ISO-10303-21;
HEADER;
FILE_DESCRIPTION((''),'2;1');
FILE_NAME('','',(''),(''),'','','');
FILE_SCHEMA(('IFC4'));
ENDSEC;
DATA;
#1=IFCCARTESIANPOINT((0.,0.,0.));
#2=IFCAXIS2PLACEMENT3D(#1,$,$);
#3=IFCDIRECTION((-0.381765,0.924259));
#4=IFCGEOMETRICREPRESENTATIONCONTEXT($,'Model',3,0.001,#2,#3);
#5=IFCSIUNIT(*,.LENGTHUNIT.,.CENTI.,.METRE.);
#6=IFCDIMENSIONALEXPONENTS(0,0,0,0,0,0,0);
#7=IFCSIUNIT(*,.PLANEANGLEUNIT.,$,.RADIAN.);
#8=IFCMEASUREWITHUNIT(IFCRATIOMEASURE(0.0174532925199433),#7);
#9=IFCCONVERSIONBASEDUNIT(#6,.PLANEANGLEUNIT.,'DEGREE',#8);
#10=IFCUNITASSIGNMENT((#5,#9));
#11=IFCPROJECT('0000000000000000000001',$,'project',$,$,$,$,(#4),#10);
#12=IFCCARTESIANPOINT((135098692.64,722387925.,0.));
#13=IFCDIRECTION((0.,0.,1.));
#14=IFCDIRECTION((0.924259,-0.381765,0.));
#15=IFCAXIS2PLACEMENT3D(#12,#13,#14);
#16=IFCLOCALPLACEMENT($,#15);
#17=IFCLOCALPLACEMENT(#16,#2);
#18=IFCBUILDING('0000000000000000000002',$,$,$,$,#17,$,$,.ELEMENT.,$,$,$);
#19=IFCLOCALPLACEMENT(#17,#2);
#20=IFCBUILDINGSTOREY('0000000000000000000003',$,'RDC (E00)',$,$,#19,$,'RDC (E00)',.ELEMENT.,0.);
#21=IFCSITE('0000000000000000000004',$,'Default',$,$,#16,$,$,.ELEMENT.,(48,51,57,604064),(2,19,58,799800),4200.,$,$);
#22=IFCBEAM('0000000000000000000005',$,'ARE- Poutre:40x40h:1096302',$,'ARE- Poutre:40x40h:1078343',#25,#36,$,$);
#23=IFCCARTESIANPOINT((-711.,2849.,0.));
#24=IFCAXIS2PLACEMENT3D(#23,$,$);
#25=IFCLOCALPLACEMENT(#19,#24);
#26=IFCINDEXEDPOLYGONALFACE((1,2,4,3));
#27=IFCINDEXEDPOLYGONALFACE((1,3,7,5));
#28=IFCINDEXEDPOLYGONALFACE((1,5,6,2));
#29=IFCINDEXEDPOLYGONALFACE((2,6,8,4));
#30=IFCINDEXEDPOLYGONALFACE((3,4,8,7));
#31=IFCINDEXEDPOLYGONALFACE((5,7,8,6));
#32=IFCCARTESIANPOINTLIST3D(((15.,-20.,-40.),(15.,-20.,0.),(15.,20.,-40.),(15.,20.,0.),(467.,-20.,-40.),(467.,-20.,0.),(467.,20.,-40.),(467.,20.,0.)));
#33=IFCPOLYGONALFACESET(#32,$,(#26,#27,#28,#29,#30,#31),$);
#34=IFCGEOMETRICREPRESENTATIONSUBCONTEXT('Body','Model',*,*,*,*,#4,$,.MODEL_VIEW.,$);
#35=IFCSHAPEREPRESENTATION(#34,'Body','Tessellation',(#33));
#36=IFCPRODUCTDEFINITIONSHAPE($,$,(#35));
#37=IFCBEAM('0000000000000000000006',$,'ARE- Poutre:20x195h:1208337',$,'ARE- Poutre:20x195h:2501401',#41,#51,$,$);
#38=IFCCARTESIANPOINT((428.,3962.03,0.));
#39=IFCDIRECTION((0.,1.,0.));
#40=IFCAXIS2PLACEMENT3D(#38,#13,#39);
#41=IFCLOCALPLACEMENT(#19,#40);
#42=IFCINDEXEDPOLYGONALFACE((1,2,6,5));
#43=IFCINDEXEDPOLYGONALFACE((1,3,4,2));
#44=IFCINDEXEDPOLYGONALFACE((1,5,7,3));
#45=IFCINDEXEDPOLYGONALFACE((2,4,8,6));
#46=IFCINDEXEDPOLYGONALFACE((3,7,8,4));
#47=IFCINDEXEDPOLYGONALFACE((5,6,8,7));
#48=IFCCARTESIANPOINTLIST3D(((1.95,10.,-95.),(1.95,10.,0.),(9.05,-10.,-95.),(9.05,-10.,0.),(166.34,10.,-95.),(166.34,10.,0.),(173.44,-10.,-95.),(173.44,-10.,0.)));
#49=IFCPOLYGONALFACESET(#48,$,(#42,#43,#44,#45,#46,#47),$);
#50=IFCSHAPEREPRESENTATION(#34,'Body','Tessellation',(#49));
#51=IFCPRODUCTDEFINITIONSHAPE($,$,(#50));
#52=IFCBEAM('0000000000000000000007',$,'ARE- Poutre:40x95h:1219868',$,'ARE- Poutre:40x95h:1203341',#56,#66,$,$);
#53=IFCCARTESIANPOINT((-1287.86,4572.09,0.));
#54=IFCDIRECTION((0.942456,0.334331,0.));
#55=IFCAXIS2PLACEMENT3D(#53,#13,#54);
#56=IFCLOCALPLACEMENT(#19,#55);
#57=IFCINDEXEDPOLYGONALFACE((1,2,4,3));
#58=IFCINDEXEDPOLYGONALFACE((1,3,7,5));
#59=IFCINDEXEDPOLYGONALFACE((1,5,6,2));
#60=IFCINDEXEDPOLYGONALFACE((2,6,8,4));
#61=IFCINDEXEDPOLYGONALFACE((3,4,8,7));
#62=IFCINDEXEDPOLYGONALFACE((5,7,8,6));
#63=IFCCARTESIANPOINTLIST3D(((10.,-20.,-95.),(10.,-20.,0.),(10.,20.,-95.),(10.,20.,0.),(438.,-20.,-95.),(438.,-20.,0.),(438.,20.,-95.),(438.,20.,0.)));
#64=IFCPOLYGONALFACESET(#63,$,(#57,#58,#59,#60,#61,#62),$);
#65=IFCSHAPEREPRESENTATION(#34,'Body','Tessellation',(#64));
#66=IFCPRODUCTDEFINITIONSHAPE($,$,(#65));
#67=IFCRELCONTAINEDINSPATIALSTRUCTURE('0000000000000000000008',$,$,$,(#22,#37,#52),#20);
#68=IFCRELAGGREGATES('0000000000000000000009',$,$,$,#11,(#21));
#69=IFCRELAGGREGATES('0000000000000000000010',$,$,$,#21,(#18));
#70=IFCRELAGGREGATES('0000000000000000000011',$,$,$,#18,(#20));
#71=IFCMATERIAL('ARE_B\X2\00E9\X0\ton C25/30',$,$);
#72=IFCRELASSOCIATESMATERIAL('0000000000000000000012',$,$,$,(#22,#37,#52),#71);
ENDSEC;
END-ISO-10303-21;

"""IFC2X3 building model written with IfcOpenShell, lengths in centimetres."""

from ifc_helpers import new_model, entity, si_unit, converted_unit, direction, frame, frame_2d, origin, origin_2d_with_axis, place, context, subcontext, project, spatial, rectangle, extrude, clip, halfspace, material, element, save


model = new_model("IFC2X3")

# Units and contexts
model_context = context("Model", 3, precision=0.001, world=origin(), true_north=direction((-0.381765, 0.924259)))
body_context = subcontext(model_context, "Body", "Model", "MODEL_VIEW")
ifc_project = project(units=[si_unit("LENGTHUNIT", "METRE", prefix="CENTI"), converted_unit("PLANEANGLEUNIT", "DEGREE", entity("IfcRatioMeasure", 0.0174532925199433), si_unit("PLANEANGLEUNIT", "RADIAN"), dimensions=[0, 0, 0, 0, 0, 0, 0])], contexts=[model_context])

# Site, building, storey
site_placement = place(None, frame((135098692.64, 722387925.0, 0.0), z_axis=(0.0, 0.0, 1.0), x_axis=(0.924259, -0.381765, 0.0)))
site = spatial("IfcSite", under=ifc_project, at=site_placement, Name="Default", CompositionType="ELEMENT", RefLatitude=(48, 51, 57, 604064), RefLongitude=(2, 19, 58, 799800), RefElevation=4200.0)
building_placement = place(site_placement, origin())
building = spatial("IfcBuilding", under=site, at=building_placement, CompositionType="ELEMENT")
storey_placement = place(building_placement, origin())
storey = spatial("IfcBuildingStorey", under=building, at=storey_placement, Name="RDC (E00)", LongName="RDC (E00)", CompositionType="ELEMENT", Elevation=0.0)

# Beams
ifc_material = material(Name="ARE_Béton C25/30")
beam_1_placement = place(storey_placement, frame((-711.0, 2849.0, 0.0)))
element("IfcBeam", 1, at=beam_1_placement, inside=storey, material=ifc_material, Name="ARE- Poutre:40x40h:1096302", ObjectType="ARE- Poutre:40x40h:1078343", context=body_context, shape_type="SweptSolid", body=[
    extrude(rectangle(XDim=40.0, YDim=40.0, at=frame_2d((0.0, 0.0), x_axis=(1.0, 0.0))), frame((15.0, 0.0, -20.0), z_axis=(1.0, 0.0, 0.0), x_axis=(0.0, 0.0, -1.0)), (0.0, 0.0, 1.0), 452.0),
])
beam_2_placement = place(storey_placement, frame((428.0, 3962.03, 0.0), z_axis=(0.0, 0.0, 1.0), x_axis=(0.0, 1.0, 0.0)))
element("IfcBeam", 2, at=beam_2_placement, inside=storey, material=ifc_material, Name="ARE- Poutre:20x195h:1208337", ObjectType="ARE- Poutre:20x195h:2501401", context=body_context, shape_type="Clipping", body=[
    clip(clip(extrude(rectangle(XDim=95.0, YDim=20.0, at=origin_2d_with_axis()), frame((1.95, 0.0, -47.5), z_axis=(1.0, 0.0, 0.0), x_axis=(0.0, 0.0, -1.0)), (0.0, 0.0, 1.0), 171.49), halfspace(frame((166.34, 10.0, 0.0), z_axis=(0.942455, 0.334333, 0.0), x_axis=(0.0, 0.0, -1.0)), False)), halfspace(frame((-7.44, 36.48, -350.0), z_axis=(-0.942456, -0.334331, 0.0), x_axis=(-0.334331, 0.942456, 0.0)), False)),
])
beam_3_placement = place(storey_placement, frame((-1287.86, 4572.09, 0.0), z_axis=(0.0, 0.0, 1.0), x_axis=(0.942456, 0.334331, 0.0)))
element("IfcBeam", 3, at=beam_3_placement, inside=storey, material=ifc_material, Name="ARE- Poutre:40x95h:1219868", ObjectType="ARE- Poutre:40x95h:1203341", context=body_context, shape_type="SweptSolid", body=[
    extrude(rectangle(XDim=95.0, YDim=40.0, at=frame_2d((0.0, 0.0), x_axis=(1.0, 0.0))), frame((10.0, 0.0, -47.5), z_axis=(1.0, 0.0, 0.0), x_axis=(0.0, 0.0, -1.0)), (0.0, 0.0, 1.0), 428.0),
])

save(model, "model.ifc")
